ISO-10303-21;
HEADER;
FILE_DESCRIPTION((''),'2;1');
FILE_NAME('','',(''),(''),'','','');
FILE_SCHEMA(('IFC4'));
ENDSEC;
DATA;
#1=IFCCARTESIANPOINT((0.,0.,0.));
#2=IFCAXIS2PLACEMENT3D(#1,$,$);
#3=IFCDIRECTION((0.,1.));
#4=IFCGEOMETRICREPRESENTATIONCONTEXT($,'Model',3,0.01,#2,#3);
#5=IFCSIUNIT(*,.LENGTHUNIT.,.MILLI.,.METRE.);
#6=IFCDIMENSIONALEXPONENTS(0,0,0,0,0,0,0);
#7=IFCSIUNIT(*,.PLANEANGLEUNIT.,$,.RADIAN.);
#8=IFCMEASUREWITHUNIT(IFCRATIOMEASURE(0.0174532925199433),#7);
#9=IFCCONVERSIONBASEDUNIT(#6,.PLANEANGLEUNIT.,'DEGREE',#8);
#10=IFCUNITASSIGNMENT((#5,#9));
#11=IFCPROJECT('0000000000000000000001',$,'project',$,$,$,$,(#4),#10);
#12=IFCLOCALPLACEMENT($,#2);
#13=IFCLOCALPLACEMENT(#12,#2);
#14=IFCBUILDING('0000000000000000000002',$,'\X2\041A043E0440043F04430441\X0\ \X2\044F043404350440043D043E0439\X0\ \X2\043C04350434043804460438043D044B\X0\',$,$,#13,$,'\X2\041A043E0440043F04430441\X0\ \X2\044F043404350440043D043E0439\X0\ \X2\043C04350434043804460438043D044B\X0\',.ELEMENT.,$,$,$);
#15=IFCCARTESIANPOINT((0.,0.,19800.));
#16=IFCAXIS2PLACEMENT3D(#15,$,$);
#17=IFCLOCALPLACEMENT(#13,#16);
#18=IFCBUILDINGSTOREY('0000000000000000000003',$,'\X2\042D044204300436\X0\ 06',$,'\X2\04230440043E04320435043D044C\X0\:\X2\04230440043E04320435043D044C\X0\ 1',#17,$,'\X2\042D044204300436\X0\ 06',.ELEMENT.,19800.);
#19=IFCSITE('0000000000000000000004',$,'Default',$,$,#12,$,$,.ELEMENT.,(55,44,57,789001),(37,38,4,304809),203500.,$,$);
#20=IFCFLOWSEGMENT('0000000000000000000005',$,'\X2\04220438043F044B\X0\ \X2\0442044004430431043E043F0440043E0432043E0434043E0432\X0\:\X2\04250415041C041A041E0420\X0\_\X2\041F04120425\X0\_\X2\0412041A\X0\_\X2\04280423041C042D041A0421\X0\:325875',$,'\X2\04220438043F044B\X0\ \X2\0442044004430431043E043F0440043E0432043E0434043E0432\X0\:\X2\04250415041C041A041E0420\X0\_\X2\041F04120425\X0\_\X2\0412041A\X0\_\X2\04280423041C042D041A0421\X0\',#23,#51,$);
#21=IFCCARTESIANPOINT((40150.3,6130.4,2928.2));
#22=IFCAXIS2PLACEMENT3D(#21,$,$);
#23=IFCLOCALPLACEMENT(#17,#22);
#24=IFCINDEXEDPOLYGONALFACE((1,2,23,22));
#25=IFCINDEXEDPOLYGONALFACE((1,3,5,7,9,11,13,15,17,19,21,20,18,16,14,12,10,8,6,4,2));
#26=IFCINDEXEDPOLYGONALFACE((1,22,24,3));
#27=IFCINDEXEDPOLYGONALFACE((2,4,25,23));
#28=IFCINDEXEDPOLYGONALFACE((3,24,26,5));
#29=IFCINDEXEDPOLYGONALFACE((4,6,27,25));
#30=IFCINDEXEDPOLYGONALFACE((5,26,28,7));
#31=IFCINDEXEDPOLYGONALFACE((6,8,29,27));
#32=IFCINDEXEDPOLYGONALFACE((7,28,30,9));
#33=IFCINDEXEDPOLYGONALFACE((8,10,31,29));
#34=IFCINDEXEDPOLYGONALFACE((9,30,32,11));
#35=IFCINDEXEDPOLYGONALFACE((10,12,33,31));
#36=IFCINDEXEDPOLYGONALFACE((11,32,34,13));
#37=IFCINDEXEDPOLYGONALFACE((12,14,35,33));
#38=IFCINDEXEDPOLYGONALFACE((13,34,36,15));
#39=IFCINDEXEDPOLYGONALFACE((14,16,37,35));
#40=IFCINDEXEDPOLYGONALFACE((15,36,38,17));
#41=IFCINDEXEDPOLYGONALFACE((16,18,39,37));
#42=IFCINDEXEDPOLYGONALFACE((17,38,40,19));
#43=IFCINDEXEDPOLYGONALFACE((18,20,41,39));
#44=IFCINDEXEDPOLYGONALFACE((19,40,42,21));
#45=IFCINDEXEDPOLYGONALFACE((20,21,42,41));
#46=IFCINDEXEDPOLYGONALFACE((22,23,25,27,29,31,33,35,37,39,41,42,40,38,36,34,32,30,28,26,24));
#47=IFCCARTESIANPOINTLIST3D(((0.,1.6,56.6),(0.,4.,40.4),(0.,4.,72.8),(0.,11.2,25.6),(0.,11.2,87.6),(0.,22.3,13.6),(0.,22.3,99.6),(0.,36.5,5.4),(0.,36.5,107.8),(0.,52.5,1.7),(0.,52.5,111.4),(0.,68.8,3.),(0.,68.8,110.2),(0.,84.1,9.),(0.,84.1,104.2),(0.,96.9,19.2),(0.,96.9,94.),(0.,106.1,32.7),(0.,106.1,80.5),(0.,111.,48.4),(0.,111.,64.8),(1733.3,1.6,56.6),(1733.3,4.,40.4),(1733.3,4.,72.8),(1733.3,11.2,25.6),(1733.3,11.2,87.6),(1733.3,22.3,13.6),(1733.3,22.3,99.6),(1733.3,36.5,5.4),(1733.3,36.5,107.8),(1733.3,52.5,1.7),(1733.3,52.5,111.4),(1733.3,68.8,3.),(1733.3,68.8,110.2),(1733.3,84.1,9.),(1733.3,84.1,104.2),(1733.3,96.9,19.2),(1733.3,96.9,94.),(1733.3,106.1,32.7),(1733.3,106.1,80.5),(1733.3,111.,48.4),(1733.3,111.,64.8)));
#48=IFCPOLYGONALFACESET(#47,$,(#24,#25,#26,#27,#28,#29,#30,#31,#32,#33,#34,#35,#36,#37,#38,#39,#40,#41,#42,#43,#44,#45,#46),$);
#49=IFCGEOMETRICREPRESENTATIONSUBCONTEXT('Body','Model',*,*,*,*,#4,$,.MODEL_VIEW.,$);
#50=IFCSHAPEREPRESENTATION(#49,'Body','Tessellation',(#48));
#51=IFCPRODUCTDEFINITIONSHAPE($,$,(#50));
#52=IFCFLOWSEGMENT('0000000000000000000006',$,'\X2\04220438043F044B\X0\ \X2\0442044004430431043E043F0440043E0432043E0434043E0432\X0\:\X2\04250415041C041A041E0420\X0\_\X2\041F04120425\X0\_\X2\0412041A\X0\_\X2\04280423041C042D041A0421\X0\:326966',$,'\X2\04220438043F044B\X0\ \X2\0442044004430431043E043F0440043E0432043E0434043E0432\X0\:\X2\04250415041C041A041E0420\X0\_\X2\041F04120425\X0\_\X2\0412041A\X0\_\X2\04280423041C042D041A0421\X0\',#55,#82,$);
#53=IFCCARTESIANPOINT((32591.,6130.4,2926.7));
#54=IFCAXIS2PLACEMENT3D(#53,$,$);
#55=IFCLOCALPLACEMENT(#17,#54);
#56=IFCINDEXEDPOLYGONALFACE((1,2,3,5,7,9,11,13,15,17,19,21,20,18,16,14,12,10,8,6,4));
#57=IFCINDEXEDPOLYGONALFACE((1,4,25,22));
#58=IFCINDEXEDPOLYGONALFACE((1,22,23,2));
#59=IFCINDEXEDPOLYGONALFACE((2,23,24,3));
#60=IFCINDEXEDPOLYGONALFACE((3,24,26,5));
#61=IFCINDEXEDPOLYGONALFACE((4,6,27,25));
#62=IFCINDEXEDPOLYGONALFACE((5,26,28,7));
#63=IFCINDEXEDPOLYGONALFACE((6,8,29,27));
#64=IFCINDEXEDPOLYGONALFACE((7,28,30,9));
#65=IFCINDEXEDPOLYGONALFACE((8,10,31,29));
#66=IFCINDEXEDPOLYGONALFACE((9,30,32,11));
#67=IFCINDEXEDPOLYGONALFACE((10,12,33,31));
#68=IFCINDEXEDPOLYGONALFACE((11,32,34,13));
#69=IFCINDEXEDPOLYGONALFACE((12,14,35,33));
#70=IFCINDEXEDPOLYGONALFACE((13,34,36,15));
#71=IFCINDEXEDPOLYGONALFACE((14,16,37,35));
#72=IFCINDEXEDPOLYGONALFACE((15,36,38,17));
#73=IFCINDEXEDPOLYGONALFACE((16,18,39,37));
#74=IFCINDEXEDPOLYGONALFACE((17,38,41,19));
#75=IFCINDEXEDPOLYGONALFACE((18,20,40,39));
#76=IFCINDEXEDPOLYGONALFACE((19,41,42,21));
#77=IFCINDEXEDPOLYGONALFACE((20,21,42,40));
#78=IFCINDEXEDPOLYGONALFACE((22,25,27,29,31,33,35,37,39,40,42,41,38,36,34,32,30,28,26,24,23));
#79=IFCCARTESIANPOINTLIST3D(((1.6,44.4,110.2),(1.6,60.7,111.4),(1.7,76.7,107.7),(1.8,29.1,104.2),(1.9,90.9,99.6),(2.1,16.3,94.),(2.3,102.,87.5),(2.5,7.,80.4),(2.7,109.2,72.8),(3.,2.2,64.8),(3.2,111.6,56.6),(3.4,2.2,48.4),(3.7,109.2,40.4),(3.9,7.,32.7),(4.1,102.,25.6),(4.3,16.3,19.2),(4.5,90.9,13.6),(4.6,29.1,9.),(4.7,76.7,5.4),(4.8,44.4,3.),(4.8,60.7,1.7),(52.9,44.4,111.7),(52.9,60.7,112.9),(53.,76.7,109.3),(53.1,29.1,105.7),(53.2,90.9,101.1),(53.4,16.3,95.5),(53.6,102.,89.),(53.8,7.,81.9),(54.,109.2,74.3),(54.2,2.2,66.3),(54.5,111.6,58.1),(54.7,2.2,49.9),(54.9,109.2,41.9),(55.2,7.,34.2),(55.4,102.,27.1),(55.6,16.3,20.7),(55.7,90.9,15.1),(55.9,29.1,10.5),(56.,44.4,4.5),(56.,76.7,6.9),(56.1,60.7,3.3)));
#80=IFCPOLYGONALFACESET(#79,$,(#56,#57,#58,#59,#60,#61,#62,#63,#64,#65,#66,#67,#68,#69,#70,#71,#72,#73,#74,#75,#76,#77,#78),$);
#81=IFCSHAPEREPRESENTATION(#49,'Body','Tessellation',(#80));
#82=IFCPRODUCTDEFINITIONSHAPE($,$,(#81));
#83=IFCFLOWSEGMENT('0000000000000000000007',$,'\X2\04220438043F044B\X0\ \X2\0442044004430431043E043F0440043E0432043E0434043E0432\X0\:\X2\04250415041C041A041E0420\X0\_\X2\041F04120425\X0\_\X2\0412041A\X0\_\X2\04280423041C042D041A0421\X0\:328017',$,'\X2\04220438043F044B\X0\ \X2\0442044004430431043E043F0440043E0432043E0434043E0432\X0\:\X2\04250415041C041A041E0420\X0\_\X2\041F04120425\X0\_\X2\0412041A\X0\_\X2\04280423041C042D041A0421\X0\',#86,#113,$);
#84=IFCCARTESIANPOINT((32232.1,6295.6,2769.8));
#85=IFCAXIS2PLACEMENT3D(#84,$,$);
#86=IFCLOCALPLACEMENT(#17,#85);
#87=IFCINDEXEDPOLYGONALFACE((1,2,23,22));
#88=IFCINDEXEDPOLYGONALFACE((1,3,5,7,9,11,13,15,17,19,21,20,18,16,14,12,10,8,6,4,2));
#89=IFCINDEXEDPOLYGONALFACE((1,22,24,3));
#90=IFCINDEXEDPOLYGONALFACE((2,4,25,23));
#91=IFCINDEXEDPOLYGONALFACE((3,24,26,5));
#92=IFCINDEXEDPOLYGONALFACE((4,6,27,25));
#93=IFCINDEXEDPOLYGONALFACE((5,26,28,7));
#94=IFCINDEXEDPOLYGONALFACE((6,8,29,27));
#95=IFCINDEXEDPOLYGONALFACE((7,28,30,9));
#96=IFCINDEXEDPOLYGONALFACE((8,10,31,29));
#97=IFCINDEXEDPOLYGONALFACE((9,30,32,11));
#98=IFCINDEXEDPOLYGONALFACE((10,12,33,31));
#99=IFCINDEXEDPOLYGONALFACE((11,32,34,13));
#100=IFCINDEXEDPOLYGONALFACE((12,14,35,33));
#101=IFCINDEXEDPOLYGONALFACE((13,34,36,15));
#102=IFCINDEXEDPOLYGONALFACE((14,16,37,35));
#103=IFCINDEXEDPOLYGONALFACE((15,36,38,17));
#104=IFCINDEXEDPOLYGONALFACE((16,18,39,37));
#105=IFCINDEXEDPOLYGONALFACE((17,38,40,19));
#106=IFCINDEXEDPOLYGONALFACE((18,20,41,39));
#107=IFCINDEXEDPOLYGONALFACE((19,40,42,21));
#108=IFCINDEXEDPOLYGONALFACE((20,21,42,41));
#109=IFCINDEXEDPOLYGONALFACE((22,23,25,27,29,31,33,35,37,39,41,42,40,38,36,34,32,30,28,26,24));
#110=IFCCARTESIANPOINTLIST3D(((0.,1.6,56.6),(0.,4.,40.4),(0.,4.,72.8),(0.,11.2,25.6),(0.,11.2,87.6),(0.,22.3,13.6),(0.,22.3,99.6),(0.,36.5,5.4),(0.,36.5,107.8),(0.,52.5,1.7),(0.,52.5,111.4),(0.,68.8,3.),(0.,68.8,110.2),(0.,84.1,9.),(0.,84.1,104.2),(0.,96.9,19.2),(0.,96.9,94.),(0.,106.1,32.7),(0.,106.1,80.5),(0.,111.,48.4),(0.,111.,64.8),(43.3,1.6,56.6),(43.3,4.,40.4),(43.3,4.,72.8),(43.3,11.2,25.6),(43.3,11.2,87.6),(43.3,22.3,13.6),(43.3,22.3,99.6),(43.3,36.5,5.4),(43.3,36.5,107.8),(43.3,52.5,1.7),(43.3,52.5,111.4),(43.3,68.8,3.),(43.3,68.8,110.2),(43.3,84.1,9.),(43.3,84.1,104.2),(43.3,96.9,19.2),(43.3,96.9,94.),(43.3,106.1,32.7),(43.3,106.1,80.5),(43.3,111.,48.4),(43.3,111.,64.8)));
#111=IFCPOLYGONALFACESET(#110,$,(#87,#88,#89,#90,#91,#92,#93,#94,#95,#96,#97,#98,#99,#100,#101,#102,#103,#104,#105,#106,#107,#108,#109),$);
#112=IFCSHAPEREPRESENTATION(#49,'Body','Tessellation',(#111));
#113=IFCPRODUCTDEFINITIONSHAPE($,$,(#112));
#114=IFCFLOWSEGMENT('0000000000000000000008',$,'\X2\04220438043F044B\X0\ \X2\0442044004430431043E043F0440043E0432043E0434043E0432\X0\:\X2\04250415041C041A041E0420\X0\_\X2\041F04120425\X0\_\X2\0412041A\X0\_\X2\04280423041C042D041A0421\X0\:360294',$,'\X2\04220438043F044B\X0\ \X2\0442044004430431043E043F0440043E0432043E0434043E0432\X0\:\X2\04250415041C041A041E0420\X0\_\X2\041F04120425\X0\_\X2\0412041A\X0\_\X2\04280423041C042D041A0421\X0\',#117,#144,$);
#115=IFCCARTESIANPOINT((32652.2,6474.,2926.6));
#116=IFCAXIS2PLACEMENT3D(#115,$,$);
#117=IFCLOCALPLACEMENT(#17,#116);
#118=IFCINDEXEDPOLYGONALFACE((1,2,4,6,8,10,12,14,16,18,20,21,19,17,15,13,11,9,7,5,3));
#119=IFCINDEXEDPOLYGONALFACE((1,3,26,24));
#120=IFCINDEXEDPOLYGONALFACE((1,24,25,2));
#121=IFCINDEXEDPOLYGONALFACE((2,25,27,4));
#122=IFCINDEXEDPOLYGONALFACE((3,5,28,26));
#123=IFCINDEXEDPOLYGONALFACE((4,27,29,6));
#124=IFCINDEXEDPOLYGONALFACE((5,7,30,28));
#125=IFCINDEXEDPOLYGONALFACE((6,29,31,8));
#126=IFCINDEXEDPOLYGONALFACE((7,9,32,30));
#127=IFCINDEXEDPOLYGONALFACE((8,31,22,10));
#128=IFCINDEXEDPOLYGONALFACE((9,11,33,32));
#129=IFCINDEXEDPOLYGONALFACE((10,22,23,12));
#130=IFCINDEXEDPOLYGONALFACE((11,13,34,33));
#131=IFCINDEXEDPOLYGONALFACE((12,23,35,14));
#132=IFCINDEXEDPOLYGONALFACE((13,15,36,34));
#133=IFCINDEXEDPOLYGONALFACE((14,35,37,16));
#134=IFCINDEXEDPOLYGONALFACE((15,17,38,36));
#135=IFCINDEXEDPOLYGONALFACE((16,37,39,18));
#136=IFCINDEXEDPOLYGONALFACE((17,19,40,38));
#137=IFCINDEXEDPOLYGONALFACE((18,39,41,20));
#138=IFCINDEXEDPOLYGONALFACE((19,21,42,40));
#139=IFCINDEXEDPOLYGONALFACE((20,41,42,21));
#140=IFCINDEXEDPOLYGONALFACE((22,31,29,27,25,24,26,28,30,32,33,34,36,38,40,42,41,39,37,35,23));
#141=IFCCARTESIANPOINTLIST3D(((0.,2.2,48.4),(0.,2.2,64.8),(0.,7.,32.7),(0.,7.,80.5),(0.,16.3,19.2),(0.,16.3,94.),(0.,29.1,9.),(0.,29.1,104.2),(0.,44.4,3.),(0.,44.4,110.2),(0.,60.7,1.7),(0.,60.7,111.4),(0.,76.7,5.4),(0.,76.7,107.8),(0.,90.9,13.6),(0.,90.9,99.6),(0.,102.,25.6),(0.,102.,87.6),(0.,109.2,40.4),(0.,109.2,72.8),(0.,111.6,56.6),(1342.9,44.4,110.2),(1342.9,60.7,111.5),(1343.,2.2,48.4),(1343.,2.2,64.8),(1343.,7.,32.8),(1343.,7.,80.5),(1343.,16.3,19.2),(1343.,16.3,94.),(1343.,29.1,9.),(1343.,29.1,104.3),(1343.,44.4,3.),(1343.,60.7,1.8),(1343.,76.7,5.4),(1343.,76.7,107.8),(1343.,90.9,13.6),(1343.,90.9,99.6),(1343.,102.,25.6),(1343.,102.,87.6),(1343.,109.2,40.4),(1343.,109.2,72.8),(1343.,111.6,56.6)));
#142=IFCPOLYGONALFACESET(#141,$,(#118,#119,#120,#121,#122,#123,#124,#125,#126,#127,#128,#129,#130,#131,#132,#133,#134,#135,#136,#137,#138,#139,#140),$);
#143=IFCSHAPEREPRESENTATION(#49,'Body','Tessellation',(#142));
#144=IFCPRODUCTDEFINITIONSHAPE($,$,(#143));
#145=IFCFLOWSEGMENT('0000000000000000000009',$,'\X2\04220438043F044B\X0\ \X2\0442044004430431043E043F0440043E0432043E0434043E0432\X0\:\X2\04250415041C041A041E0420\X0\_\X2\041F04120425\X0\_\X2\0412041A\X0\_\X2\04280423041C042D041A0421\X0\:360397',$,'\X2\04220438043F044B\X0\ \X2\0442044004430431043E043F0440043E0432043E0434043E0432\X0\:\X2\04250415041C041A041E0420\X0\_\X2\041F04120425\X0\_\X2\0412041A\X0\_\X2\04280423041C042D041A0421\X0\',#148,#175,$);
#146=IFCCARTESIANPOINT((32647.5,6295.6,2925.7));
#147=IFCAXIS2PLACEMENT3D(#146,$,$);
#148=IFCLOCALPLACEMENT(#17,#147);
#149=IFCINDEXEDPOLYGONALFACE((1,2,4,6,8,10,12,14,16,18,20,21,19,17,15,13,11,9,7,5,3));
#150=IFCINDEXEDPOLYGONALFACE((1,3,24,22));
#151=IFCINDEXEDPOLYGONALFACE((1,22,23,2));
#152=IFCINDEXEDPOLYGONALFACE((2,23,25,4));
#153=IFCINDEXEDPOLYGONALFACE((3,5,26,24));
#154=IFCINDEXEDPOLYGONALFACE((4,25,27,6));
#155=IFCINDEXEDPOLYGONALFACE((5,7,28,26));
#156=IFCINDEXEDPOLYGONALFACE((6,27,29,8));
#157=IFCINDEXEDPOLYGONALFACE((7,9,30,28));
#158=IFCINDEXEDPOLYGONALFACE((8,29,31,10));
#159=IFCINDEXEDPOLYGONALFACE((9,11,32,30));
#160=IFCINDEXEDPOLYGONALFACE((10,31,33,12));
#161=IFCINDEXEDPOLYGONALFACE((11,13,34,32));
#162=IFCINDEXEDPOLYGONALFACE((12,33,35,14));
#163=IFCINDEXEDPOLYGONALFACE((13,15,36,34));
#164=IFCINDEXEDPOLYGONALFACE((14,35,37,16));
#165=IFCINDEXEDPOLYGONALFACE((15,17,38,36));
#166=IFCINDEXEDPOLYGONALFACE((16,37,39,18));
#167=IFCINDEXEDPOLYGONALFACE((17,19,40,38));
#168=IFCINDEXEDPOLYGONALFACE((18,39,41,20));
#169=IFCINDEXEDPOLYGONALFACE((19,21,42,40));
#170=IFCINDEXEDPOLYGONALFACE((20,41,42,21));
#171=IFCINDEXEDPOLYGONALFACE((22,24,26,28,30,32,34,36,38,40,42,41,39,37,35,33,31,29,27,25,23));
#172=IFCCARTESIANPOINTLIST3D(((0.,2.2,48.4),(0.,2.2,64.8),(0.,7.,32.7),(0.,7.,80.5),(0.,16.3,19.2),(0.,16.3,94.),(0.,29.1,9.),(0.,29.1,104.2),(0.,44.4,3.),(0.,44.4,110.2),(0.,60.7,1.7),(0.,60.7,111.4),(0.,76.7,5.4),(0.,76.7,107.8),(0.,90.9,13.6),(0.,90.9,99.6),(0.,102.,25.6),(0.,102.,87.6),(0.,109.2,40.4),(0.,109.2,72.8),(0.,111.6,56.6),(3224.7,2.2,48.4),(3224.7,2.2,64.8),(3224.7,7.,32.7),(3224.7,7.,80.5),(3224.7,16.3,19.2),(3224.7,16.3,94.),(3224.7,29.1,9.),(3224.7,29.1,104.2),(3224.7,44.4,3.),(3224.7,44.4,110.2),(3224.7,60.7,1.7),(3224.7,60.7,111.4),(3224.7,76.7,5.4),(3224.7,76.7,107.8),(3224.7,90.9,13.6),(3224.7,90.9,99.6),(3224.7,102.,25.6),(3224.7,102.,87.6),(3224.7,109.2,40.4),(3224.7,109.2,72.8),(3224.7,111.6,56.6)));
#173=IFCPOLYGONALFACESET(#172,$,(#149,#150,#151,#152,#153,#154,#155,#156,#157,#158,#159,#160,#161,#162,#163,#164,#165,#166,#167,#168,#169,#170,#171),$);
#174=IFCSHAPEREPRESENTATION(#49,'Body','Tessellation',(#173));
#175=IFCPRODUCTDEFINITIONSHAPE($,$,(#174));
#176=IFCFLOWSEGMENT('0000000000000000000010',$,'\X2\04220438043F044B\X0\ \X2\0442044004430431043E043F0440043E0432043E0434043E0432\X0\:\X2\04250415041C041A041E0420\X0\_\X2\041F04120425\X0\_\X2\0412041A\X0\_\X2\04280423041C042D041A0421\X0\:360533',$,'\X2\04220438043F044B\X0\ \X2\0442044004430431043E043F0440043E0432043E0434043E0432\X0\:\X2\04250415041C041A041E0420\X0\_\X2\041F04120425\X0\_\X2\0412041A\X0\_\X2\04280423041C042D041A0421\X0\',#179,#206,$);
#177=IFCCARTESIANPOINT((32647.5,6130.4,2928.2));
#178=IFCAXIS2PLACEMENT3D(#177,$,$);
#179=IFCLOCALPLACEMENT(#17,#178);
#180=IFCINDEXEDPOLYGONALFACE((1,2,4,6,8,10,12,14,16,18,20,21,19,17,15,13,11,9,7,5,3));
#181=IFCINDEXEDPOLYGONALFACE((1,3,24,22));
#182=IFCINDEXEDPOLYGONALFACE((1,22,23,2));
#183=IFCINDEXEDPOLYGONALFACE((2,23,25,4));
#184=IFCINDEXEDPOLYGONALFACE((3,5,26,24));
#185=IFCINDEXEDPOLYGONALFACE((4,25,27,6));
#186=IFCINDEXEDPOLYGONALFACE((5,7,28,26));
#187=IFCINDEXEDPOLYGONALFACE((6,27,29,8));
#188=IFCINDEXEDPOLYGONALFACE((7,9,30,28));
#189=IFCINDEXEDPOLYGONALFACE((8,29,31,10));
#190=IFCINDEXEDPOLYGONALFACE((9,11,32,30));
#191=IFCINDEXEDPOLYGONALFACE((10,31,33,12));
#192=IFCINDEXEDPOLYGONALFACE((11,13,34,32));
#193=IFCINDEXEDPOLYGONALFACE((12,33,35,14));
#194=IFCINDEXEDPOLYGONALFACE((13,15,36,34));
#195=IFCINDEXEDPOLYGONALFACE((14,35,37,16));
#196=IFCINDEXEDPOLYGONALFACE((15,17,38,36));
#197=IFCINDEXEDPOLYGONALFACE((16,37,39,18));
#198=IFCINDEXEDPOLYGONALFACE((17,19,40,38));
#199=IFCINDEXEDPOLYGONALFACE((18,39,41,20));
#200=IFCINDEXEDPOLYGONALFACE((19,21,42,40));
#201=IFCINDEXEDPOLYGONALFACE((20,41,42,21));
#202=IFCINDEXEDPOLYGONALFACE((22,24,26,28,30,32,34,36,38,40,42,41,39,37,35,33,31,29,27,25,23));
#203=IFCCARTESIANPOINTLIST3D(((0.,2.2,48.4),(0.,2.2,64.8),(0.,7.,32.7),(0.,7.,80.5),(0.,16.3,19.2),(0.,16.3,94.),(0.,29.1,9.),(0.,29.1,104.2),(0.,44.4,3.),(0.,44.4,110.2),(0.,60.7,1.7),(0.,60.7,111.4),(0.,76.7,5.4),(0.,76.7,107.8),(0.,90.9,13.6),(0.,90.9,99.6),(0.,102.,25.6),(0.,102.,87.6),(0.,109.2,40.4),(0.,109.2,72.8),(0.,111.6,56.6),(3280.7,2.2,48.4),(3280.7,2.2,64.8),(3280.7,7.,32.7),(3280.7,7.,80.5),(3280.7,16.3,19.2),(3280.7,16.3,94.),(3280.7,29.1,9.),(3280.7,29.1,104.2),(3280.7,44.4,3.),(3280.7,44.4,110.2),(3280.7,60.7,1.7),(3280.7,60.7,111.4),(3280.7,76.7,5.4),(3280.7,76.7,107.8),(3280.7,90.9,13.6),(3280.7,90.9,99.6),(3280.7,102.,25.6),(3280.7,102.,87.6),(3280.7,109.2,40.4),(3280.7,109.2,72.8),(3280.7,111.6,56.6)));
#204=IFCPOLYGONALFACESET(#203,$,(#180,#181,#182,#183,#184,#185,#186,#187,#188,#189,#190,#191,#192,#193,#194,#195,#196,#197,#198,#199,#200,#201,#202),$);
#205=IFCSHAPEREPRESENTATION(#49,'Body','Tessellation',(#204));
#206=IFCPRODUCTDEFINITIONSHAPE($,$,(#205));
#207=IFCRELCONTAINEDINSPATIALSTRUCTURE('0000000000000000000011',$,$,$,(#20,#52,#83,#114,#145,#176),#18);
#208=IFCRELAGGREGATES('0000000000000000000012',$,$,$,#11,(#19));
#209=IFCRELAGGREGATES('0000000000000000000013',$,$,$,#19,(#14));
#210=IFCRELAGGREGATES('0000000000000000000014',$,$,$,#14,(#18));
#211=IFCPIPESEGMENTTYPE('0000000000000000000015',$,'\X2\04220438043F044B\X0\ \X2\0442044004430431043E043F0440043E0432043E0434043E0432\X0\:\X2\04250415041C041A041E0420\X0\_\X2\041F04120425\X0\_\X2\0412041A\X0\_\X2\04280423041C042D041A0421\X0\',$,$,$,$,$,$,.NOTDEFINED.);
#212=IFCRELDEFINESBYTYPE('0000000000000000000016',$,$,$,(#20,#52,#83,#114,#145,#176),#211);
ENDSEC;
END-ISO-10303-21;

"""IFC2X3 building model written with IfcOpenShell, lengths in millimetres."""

from ifc_helpers import new_model, entity, si_unit, converted_unit, direction, frame, frame_2d, origin, origin_2d_with_axis, place, context, subcontext, project, spatial, circle, extrude, type_object, element, save


model = new_model("IFC2X3")

# Units and contexts
model_context = context("Model", 3, precision=0.01, world=origin(), true_north=direction((0.0, 1.0)))
body_context = subcontext(model_context, "Body", "Model", "MODEL_VIEW")
ifc_project = project(units=[si_unit("LENGTHUNIT", "METRE", prefix="MILLI"), converted_unit("PLANEANGLEUNIT", "DEGREE", entity("IfcRatioMeasure", 0.0174532925199433), si_unit("PLANEANGLEUNIT", "RADIAN"), dimensions=[0, 0, 0, 0, 0, 0, 0])], contexts=[model_context])

# Site, building, storey
site_placement = place(None, frame((0.0, 0.0, 0.0)))
site = spatial("IfcSite", under=ifc_project, at=site_placement, Name="Default", CompositionType="ELEMENT", RefLatitude=(55, 44, 57, 789001), RefLongitude=(37, 38, 4, 304809), RefElevation=203500.0)
building_placement = place(site_placement, origin())
building = spatial("IfcBuilding", under=site, at=building_placement, Name="Корпус ядерной медицины", LongName="Корпус ядерной медицины", CompositionType="ELEMENT")
storey_placement = place(building_placement, frame((0.0, 0.0, 19800.0)))
storey = spatial("IfcBuildingStorey", under=building, at=storey_placement, Name="Этаж 06", ObjectType="Уровень:Уровень 1", LongName="Этаж 06", CompositionType="ELEMENT", Elevation=19800.0)

# Flow segments
pipe_segment_type = type_object("IfcPipeSegmentType", Name="Типы трубопроводов:ХЕМКОР_ПВХ_ВК_ШУМЭКС", PredefinedType="NOTDEFINED")
flow_segment_1_placement = place(storey_placement, frame((40150.3, 6130.4, 2928.2)))
element("IfcFlowSegment", 1, at=flow_segment_1_placement, inside=storey, type_object=pipe_segment_type, Name="Типы трубопроводов:ХЕМКОР_ПВХ_ВК_ШУМЭКС:325875", ObjectType="Типы трубопроводов:ХЕМКОР_ПВХ_ВК_ШУМЭКС", context=body_context, shape_type="SweptSolid", body=[
    extrude(circle(Radius=55.0, at=origin_2d_with_axis()), frame((0.0, 56.6, 56.6), z_axis=(1.0, 0.0, 0.0), x_axis=(0.0, -1.0, 0.0)), (0.0, 0.0, 1.0), 1733.3),
])
flow_segment_2_placement = place(storey_placement, frame((32591.0, 6130.4, 2926.7)))
element("IfcFlowSegment", 2, at=flow_segment_2_placement, inside=storey, type_object=pipe_segment_type, Name="Типы трубопроводов:ХЕМКОР_ПВХ_ВК_ШУМЭКС:326966", ObjectType="Типы трубопроводов:ХЕМКОР_ПВХ_ВК_ШУМЭКС", context=body_context, shape_type="SweptSolid", body=[
    extrude(circle(Radius=55.0, at=frame_2d((0.0, 0.0), x_axis=(1.0, 0.0))), frame((3.2, 56.6, 56.6), z_axis=(0.999571, 0.0, 0.029297), x_axis=(0.0, 1.0, 0.0)), (0.0, 0.0, 1.0), 51.3),
])
flow_segment_3_placement = place(storey_placement, frame((32232.1, 6295.6, 2769.8)))
element("IfcFlowSegment", 3, at=flow_segment_3_placement, inside=storey, type_object=pipe_segment_type, Name="Типы трубопроводов:ХЕМКОР_ПВХ_ВК_ШУМЭКС:328017", ObjectType="Типы трубопроводов:ХЕМКОР_ПВХ_ВК_ШУМЭКС", context=body_context, shape_type="SweptSolid", body=[
    extrude(circle(Radius=55.0, at=origin_2d_with_axis()), frame((0.0, 56.6, 56.6), z_axis=(1.0, 0.0, 0.0), x_axis=(0.0, -1.0, 0.0)), (0.0, 0.0, 1.0), 43.3),
])
flow_segment_4_placement = place(storey_placement, frame((32652.2, 6474.0, 2926.6)))
element("IfcFlowSegment", 4, at=flow_segment_4_placement, inside=storey, type_object=pipe_segment_type, Name="Типы трубопроводов:ХЕМКОР_ПВХ_ВК_ШУМЭКС:360294", ObjectType="Типы трубопроводов:ХЕМКОР_ПВХ_ВК_ШУМЭКС", context=body_context, shape_type="SweptSolid", body=[
    extrude(circle(Radius=55.0, at=frame_2d((0.0, 0.0), x_axis=(1.0, 0.0))), frame((0.0, 56.6, 56.6), z_axis=(1.0, 0.0, 0.000022), x_axis=(0.0, 1.0, 0.0)), (0.0, 0.0, 1.0), 1342.9),
])
flow_segment_5_placement = place(storey_placement, frame((32647.5, 6295.6, 2925.7)))
element("IfcFlowSegment", 5, at=flow_segment_5_placement, inside=storey, type_object=pipe_segment_type, Name="Типы трубопроводов:ХЕМКОР_ПВХ_ВК_ШУМЭКС:360397", ObjectType="Типы трубопроводов:ХЕМКОР_ПВХ_ВК_ШУМЭКС", context=body_context, shape_type="SweptSolid", body=[
    extrude(circle(Radius=55.0, at=frame_2d((0.0, 0.0), x_axis=(1.0, 0.0))), frame((0.0, 56.6, 56.6), z_axis=(1.0, 0.0, 0.0), x_axis=(0.0, 1.0, 0.0)), (0.0, 0.0, 1.0), 3224.7),
])
flow_segment_6_placement = place(storey_placement, frame((32647.5, 6130.4, 2928.2)))
element("IfcFlowSegment", 6, at=flow_segment_6_placement, inside=storey, type_object=pipe_segment_type, Name="Типы трубопроводов:ХЕМКОР_ПВХ_ВК_ШУМЭКС:360533", ObjectType="Типы трубопроводов:ХЕМКОР_ПВХ_ВК_ШУМЭКС", context=body_context, shape_type="SweptSolid", body=[
    extrude(circle(Radius=55.0, at=frame_2d((0.0, 0.0), x_axis=(1.0, 0.0))), frame((0.0, 56.6, 56.6), z_axis=(1.0, 0.0, 0.0), x_axis=(0.0, 1.0, 0.0)), (0.0, 0.0, 1.0), 3280.7),
])

save(model, "model.ifc")
